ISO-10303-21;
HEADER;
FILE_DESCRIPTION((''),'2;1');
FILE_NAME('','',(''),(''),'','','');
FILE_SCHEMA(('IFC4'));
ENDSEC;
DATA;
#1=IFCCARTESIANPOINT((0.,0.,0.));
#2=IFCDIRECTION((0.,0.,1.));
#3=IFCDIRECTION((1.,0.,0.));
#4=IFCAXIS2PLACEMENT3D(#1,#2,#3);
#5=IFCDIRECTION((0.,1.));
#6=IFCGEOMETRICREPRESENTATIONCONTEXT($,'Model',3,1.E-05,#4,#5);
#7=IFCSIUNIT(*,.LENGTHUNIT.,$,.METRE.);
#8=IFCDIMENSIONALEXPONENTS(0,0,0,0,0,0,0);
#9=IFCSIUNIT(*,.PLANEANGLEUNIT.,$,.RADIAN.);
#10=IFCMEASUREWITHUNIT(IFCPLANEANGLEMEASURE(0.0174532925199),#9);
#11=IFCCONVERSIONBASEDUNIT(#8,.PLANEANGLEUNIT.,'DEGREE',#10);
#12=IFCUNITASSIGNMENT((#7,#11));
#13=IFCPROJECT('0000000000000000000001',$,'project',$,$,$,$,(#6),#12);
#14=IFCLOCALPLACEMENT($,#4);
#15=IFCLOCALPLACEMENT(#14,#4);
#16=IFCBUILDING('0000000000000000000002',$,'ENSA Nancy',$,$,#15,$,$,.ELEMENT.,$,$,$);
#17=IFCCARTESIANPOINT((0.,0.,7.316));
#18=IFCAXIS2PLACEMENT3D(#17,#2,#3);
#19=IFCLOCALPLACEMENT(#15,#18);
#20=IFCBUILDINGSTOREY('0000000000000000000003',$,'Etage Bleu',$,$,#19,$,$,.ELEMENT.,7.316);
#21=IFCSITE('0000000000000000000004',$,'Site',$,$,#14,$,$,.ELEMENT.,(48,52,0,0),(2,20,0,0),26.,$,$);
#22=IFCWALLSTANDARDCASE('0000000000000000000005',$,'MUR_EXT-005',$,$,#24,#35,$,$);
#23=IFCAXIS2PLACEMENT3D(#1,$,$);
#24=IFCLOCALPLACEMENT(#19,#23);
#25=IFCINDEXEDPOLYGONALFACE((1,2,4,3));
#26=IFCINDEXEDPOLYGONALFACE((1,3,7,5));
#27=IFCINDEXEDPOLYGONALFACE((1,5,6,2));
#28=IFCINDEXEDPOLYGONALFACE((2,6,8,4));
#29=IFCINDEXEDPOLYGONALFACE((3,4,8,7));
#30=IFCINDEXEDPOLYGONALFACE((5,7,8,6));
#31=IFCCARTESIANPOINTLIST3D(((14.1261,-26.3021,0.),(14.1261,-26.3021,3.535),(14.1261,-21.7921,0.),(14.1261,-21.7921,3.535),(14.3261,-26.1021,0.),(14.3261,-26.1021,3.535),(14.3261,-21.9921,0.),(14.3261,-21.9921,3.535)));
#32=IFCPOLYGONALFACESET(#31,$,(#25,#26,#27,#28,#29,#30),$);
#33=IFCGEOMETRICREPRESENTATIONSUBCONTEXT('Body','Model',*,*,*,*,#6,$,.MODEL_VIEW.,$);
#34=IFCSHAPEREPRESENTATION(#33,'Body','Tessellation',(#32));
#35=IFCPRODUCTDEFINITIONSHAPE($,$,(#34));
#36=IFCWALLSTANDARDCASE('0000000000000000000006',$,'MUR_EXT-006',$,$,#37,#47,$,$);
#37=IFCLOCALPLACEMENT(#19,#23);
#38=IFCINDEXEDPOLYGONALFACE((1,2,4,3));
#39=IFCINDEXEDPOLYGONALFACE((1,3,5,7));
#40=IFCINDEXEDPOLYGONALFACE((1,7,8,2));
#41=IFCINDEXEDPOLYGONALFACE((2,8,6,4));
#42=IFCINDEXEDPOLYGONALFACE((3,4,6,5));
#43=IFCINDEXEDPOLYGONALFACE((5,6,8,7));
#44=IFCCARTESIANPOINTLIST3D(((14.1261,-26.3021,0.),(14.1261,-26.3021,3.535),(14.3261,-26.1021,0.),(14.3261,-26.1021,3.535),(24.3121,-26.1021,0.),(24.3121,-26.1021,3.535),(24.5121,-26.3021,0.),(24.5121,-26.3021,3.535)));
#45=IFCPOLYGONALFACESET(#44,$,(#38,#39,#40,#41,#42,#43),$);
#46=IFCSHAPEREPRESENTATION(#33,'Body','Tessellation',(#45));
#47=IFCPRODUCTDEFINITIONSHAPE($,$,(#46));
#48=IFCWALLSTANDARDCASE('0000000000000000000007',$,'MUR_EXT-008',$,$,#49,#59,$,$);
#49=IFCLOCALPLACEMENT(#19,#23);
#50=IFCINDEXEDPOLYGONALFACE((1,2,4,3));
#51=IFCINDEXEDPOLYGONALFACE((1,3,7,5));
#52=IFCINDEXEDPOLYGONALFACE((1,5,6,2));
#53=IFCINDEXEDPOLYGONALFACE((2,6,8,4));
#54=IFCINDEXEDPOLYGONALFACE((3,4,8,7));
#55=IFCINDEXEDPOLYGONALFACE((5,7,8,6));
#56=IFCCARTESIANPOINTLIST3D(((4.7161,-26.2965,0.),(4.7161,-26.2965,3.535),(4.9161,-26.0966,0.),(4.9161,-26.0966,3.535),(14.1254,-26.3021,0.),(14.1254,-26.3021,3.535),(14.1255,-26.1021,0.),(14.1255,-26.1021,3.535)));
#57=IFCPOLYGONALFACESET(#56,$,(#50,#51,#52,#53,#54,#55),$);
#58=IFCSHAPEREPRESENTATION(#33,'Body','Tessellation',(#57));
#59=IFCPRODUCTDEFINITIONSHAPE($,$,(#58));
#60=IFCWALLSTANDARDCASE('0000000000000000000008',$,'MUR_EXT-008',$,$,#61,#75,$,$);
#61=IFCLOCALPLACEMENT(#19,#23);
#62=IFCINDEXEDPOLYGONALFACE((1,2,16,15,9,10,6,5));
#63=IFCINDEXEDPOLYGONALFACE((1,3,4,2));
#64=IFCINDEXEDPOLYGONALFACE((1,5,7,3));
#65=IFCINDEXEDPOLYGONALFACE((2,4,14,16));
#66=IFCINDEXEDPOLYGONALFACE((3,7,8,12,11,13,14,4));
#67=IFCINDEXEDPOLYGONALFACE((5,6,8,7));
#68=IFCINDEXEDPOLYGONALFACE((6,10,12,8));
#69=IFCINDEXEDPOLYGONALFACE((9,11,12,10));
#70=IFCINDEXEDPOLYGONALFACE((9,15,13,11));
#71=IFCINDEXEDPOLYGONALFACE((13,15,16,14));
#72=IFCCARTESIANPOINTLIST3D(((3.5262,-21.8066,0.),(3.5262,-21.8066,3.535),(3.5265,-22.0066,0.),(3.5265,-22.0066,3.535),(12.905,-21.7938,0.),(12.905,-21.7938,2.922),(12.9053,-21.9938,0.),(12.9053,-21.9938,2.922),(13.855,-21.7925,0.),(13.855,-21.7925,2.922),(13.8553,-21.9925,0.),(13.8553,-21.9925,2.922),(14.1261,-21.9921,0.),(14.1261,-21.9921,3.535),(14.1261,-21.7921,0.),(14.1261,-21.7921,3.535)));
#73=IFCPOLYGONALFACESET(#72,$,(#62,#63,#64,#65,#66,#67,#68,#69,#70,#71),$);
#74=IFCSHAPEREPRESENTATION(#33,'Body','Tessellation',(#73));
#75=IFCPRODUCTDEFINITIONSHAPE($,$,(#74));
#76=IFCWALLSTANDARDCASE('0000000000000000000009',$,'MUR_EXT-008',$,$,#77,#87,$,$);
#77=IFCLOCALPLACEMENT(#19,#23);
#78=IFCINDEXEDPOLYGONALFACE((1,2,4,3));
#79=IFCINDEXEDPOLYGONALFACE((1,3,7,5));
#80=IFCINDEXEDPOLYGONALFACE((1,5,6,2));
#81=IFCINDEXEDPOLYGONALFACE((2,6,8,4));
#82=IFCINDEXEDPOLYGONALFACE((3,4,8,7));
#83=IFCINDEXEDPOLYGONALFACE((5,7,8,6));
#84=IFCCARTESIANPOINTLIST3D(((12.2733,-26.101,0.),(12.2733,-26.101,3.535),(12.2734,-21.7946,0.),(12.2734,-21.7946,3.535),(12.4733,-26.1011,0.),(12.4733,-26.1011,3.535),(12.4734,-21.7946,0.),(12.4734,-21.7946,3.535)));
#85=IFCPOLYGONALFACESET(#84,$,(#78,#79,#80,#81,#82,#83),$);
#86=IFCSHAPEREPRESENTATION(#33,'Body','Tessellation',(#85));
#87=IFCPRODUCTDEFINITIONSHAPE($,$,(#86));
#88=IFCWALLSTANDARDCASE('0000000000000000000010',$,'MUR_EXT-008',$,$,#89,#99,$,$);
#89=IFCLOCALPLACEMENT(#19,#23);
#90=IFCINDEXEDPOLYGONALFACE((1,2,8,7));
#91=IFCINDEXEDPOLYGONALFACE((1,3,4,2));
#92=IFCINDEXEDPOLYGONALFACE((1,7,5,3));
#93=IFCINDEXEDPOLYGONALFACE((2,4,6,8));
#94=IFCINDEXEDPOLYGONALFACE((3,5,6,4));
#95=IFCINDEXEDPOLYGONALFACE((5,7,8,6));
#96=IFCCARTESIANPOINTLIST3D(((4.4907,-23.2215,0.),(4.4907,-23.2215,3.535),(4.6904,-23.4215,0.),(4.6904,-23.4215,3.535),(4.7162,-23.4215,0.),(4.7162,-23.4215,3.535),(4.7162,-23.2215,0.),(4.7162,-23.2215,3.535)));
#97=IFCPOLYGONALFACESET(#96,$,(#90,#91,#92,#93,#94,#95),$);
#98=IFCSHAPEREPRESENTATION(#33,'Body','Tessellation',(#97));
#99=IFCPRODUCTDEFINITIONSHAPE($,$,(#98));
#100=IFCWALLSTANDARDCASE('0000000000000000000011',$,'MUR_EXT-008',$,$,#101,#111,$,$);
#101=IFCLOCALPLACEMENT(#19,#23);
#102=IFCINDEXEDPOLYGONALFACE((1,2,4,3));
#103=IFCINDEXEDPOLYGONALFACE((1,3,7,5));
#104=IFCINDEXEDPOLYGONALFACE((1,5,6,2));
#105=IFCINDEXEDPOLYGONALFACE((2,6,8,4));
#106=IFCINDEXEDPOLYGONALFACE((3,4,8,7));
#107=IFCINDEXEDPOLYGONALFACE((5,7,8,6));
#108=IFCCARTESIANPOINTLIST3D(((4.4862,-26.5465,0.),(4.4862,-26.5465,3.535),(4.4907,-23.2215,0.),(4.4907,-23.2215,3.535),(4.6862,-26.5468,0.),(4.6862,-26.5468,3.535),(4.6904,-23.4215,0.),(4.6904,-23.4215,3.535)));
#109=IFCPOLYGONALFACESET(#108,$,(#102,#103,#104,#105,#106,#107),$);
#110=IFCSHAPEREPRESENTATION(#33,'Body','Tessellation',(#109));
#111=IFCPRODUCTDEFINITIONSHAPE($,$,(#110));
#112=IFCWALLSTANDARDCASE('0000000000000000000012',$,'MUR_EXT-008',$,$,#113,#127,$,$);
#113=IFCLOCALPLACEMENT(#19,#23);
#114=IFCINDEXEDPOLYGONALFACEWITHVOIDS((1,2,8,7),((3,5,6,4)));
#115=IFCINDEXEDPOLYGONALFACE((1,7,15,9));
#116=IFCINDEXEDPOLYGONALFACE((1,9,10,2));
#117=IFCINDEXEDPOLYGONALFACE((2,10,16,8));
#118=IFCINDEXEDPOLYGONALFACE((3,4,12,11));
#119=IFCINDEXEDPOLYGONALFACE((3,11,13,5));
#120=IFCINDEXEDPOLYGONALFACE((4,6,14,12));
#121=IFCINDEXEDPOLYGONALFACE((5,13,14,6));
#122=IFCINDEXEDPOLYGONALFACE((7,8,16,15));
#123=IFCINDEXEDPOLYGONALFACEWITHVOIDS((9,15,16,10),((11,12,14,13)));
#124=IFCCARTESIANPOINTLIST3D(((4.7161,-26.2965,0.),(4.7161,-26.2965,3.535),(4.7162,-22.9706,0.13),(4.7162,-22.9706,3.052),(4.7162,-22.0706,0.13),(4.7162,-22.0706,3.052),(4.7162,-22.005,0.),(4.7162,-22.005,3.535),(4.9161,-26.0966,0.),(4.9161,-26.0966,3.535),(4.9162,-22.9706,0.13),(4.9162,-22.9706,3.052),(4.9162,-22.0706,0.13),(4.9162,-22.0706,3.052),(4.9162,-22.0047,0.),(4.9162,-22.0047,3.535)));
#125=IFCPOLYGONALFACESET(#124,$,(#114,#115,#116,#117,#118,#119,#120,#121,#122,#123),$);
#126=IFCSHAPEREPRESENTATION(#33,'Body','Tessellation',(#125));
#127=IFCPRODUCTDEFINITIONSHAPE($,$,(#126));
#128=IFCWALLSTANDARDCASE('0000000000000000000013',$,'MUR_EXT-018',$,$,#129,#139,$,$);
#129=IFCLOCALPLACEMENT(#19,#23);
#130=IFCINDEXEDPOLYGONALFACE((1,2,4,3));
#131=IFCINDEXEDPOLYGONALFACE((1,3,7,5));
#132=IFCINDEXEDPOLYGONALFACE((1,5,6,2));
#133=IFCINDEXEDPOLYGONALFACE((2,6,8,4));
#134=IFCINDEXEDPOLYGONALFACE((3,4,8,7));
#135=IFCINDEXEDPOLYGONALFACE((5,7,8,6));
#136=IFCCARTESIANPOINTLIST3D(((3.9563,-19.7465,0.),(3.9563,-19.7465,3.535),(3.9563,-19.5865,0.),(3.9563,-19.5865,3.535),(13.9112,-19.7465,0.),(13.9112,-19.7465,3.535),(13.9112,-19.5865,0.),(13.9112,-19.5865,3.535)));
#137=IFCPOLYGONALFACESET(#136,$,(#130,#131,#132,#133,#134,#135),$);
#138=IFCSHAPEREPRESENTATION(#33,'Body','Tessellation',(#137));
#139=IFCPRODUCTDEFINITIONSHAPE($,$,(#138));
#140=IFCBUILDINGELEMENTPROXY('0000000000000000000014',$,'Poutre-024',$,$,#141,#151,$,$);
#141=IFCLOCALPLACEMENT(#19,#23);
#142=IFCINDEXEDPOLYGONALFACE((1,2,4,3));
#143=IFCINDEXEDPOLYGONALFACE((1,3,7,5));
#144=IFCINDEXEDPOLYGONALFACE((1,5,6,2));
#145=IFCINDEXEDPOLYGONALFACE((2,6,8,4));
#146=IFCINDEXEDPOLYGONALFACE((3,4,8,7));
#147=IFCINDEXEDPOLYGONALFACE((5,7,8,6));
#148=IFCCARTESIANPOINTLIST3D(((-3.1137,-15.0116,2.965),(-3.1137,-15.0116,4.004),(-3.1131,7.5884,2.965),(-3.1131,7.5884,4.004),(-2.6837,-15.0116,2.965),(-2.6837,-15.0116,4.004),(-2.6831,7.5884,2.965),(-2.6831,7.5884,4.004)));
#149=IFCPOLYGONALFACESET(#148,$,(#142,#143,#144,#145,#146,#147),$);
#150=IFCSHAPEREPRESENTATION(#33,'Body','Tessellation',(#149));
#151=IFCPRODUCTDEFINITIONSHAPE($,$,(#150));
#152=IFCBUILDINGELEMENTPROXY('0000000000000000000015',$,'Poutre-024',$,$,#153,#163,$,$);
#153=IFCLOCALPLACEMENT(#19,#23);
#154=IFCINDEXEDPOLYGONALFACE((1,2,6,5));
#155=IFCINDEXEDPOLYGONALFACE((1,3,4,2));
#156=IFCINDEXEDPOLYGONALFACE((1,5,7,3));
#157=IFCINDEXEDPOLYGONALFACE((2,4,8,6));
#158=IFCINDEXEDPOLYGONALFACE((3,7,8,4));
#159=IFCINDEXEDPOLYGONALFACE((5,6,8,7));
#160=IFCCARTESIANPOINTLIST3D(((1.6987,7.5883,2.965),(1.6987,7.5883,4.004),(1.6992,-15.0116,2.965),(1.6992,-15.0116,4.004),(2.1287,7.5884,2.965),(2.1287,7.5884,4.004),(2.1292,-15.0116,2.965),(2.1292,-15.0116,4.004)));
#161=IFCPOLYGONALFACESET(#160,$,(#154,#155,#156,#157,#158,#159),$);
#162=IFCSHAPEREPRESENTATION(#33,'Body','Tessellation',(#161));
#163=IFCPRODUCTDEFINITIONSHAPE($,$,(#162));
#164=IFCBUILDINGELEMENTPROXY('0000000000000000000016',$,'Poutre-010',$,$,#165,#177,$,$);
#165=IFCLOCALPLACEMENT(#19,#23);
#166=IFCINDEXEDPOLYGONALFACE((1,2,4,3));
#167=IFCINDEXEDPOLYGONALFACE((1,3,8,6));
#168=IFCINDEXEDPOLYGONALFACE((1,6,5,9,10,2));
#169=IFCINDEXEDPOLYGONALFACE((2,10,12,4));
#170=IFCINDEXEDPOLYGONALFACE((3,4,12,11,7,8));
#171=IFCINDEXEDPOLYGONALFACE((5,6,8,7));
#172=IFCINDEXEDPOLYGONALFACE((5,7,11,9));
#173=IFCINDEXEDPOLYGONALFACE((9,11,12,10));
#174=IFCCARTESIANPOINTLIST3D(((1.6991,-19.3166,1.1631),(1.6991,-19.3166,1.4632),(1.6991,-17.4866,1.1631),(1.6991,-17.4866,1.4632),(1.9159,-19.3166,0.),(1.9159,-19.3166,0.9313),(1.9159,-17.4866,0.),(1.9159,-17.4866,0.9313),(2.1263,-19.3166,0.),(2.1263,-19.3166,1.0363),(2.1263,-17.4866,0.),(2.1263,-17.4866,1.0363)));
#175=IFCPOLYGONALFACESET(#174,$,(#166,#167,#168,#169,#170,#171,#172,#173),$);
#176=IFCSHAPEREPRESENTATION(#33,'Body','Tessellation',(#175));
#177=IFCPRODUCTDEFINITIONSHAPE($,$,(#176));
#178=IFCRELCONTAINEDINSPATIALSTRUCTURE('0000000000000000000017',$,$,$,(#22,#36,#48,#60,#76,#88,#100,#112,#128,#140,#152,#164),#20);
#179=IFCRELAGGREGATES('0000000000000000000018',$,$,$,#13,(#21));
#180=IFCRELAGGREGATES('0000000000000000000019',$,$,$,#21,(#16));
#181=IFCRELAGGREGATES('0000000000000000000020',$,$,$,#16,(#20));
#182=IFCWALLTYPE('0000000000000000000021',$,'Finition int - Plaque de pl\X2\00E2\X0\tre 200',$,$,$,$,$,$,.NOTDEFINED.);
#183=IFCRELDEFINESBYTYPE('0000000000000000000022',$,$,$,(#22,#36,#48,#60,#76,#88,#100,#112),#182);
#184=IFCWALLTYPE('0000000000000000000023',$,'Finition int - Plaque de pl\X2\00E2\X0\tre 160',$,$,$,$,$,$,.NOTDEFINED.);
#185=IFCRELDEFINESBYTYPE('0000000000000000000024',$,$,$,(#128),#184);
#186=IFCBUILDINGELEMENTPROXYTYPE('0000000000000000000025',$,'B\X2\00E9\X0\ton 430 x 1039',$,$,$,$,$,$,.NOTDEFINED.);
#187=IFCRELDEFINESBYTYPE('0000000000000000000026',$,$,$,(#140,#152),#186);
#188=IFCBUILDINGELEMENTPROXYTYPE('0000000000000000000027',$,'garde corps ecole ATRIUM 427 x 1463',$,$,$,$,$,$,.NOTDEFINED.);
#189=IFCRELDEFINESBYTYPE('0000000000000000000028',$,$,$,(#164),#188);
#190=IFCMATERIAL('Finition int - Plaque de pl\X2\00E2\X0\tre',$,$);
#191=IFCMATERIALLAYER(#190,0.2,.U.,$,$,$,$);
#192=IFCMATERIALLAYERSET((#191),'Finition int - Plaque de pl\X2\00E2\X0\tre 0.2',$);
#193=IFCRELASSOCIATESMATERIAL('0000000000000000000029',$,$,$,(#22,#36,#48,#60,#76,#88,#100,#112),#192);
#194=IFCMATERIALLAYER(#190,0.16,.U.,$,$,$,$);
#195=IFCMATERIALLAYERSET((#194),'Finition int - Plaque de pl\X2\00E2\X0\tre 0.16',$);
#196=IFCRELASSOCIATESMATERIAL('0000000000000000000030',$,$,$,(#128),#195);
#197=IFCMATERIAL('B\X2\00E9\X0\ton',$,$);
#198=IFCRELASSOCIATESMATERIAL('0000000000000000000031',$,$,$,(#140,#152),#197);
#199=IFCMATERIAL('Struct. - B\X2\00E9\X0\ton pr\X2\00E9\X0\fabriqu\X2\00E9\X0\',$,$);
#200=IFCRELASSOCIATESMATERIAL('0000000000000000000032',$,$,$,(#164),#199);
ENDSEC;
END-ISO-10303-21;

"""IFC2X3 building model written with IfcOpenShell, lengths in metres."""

from ifc_helpers import new_model, entity, si_unit, converted_unit, direction, frame, frame_2d, origin_with_axes, origin_2d_with_axis, place, context, subcontext, project, spatial, polyline, rectangle, outline, extrude, material, layer, layer_set, layer_usage, type_object, element, save


model = new_model("IFC2X3")

# Units and contexts
model_context = context("Model", 3, precision=1e-05, world=origin_with_axes(), true_north=direction((0.0, 1.0)))
body_context = subcontext(model_context, "Body", "Model", "MODEL_VIEW")
ifc_project = project(units=[si_unit("LENGTHUNIT", "METRE"), converted_unit("PLANEANGLEUNIT", "DEGREE", entity("IfcPlaneAngleMeasure", 0.0174532925199), si_unit("PLANEANGLEUNIT", "RADIAN"), dimensions=[0, 0, 0, 0, 0, 0, 0])], contexts=[model_context])

# Site, building, storey
site_placement = place(None, origin_with_axes())
site = spatial("IfcSite", under=ifc_project, at=site_placement, Name="Site", CompositionType="ELEMENT", RefLatitude=(48, 52, 0, 0), RefLongitude=(2, 20, 0, 0), RefElevation=26.0)
building_placement = place(site_placement, origin_with_axes())
building = spatial("IfcBuilding", under=site, at=building_placement, Name="ENSA Nancy", CompositionType="ELEMENT")
storey_placement = place(building_placement, frame((0.0, 0.0, 7.316), z_axis=(0.0, 0.0, 1.0), x_axis=(1.0, 0.0, 0.0)))
storey = spatial("IfcBuildingStorey", under=building, at=storey_placement, Name="Etage Bleu", CompositionType="ELEMENT", Elevation=7.316)

# Walls
ifc_material_1 = material(Name="Finition int - Plaque de plâtre")
ifc_layer_1 = layer(ifc_material_1, 0.2, ventilated="UNKNOWN")
ifc_layer_set_1 = layer_set([ifc_layer_1], Name="Finition int - Plaque de plâtre 0.2")
ifc_layer_usage_1 = layer_usage(ifc_layer_set_1, "AXIS2", "POSITIVE", 0.0)
wall_type_1 = type_object("IfcWallType", Name="Finition int - Plaque de plâtre 200", PredefinedType="NOTDEFINED")
wall_1_placement = place(storey_placement, frame((14.1261, -21.7921, 0.0), z_axis=(0.0, 0.0, 1.0), x_axis=(0.0, -1.0, 0.0)))
element("IfcWallStandardCase", 1, at=wall_1_placement, inside=storey, type_object=wall_type_1, material=ifc_layer_usage_1, Name="MUR_EXT-005", context=body_context, shape_type="SweptSolid", body=[
    extrude(outline(polyline([(0.0, 0.0), (4.51, 0.0), (4.31, 0.2), (0.2, 0.2), (0.0, 0.0)])), origin_with_axes(), (0.0, 0.0, 1.0), 3.535),
])
ifc_layer_usage_2 = layer_usage(ifc_layer_set_1, "AXIS2", "POSITIVE", 0.0)
wall_2_placement = place(storey_placement, frame((14.1261, -26.3021, 0.0), z_axis=(0.0, 0.0, 1.0), x_axis=(1.0, 0.000003, 0.0)))
element("IfcWallStandardCase", 2, at=wall_2_placement, inside=storey, type_object=wall_type_1, material=ifc_layer_usage_2, Name="MUR_EXT-006", context=body_context, shape_type="SweptSolid", body=[
    extrude(outline(polyline([(0.0, 0.0), (10.386, 0.0), (10.186, 0.2), (0.2, 0.2), (0.0, 0.0)])), origin_with_axes(), (0.0, 0.0, 1.0), 3.535),
])
ifc_layer_usage_3 = layer_usage(ifc_layer_set_1, "AXIS2", "POSITIVE", 0.0)
wall_3_placement = place(storey_placement, frame((4.7161, -26.2965, 0.0), z_axis=(0.0, 0.0, 1.0), x_axis=(1.0, -0.000596, 0.0)))
element("IfcWallStandardCase", 3, at=wall_3_placement, inside=storey, type_object=wall_type_1, material=ifc_layer_usage_3, Name="MUR_EXT-008", context=body_context, shape_type="SweptSolid", body=[
    extrude(outline(polyline([(0.0, 0.0), (9.4092, 0.0), (9.4092, 0.2), (0.1999, 0.2), (0.0, 0.0)])), origin_with_axes(), (0.0, 0.0, 1.0), 3.535),
])

# Wall, opening
ifc_layer_usage_4 = layer_usage(ifc_layer_set_1, "AXIS2", "NEGATIVE", 0.0)
wall_4_placement = place(storey_placement, frame((3.5262, -21.8066, 0.0), z_axis=(0.0, 0.0, 1.0), x_axis=(0.999999, 0.001365, 0.0)))
wall_4 = element("IfcWallStandardCase", 4, at=wall_4_placement, inside=storey, type_object=wall_type_1, material=ifc_layer_usage_4, Name="MUR_EXT-008", context=body_context, shape_type="SweptSolid", body=[
    extrude(outline(polyline([(0.0, -0.2), (10.5996, -0.2), (10.5999, 0.0), (0.0, 0.0), (0.0, -0.2)])), origin_with_axes(), (0.0, 0.0, 1.0), 3.535),
])
opening_1_placement = place(wall_4_placement, frame((9.8538, 0.0, 0.0), z_axis=(0.0, 0.0, 1.0), x_axis=(1.0, 0.0, 0.0)))
element("IfcOpeningElement", 5, at=opening_1_placement, cuts=wall_4, context=body_context, shape_type="SweptSolid", body=[
    extrude(rectangle(XDim=0.95, YDim=2.922, at=origin_2d_with_axis()), frame((0.0, -0.2, 1.461), z_axis=(0.0, 1.0, 0.0), x_axis=(1.0, 0.0, 0.0)), (0.0, 0.0, 1.0), 0.6),
])

# Walls
ifc_layer_usage_5 = layer_usage(ifc_layer_set_1, "AXIS2", "POSITIVE", 0.0)
wall_5_placement = place(storey_placement, frame((12.2734, -21.7946, 0.0), z_axis=(0.0, 0.0, 1.0), x_axis=(-0.000007, -1.0, 0.0)))
element("IfcWallStandardCase", 6, at=wall_5_placement, inside=storey, type_object=wall_type_1, material=ifc_layer_usage_5, Name="MUR_EXT-008", context=body_context, shape_type="SweptSolid", body=[
    extrude(outline(polyline([(0.0, 0.0), (4.3065, 0.0), (4.3066, 0.2), (0.0, 0.2), (0.0, 0.0)])), origin_with_axes(), (0.0, 0.0, 1.0), 3.535),
])
ifc_layer_usage_6 = layer_usage(ifc_layer_set_1, "AXIS2", "POSITIVE", 0.0)
wall_6_placement = place(storey_placement, frame((4.7162, -23.2215, 0.0), z_axis=(0.0, 0.0, 1.0), x_axis=(-1.0, 0.0, 0.0)))
element("IfcWallStandardCase", 7, at=wall_6_placement, inside=storey, type_object=wall_type_1, material=ifc_layer_usage_6, Name="MUR_EXT-008", context=body_context, shape_type="SweptSolid", body=[
    extrude(outline(polyline([(0.0, 0.0), (0.2255, 0.0), (0.0258, 0.2), (0.0, 0.2), (0.0, 0.0)])), origin_with_axes(), (0.0, 0.0, 1.0), 3.535),
])
ifc_layer_usage_7 = layer_usage(ifc_layer_set_1, "AXIS2", "POSITIVE", 0.0)
wall_7_placement = place(storey_placement, frame((4.4907, -23.2215, 0.0), z_axis=(0.0, 0.0, 1.0), x_axis=(-0.001341, -0.999999, 0.0)))
element("IfcWallStandardCase", 8, at=wall_7_placement, inside=storey, type_object=wall_type_1, material=ifc_layer_usage_7, Name="MUR_EXT-008", context=body_context, shape_type="SweptSolid", body=[
    extrude(outline(polyline([(0.0, 0.0), (3.325, 0.0), (3.325, 0.2), (0.1997, 0.2), (0.0, 0.0)])), origin_with_axes(), (0.0, 0.0, 1.0), 3.535),
])

# Wall, opening
ifc_layer_usage_8 = layer_usage(ifc_layer_set_1, "AXIS2", "POSITIVE", 0.0)
wall_8_placement = place(storey_placement, frame((4.7162, -21.805, 0.0), z_axis=(0.0, 0.0, 1.0), x_axis=(-0.000007, -1.0, 0.0)))
wall_8 = element("IfcWallStandardCase", 9, at=wall_8_placement, inside=storey, type_object=wall_type_1, material=ifc_layer_usage_8, Name="MUR_EXT-008", context=body_context, shape_type="SweptSolid", body=[
    extrude(outline(polyline([(0.2, 0.0), (4.4915, 0.0), (4.2917, 0.2), (0.1997, 0.2), (0.2, 0.0)])), origin_with_axes(), (0.0, 0.0, 1.0), 3.535),
])
opening_2_placement = place(wall_8_placement, frame((0.7156, 0.0, 0.13), z_axis=(0.0, 0.0, 1.0), x_axis=(1.0, 0.0, 0.0)))
element("IfcOpeningElement", 10, at=opening_2_placement, cuts=wall_8, context=body_context, shape_type="SweptSolid", body=[
    extrude(rectangle(XDim=0.9, YDim=2.922, at=origin_2d_with_axis()), frame((0.0, 0.2, 1.461), z_axis=(0.0, 1.0, 0.0), x_axis=(-1.0, 0.0, 0.0)), (0.0, 0.0, -1.0), 0.6),
])

# Wall
ifc_layer_2 = layer(ifc_material_1, 0.16, ventilated="UNKNOWN")
ifc_layer_set_2 = layer_set([ifc_layer_2], Name="Finition int - Plaque de plâtre 0.16")
ifc_layer_usage_9 = layer_usage(ifc_layer_set_2, "AXIS2", "POSITIVE", -0.16)
wall_type_2 = type_object("IfcWallType", Name="Finition int - Plaque de plâtre 160", PredefinedType="NOTDEFINED")
wall_9_placement = place(storey_placement, frame((3.9563, -19.5865, 0.0), z_axis=(0.0, 0.0, 1.0), x_axis=(1.0, 0.0, 0.0)))
element("IfcWallStandardCase", 11, at=wall_9_placement, inside=storey, type_object=wall_type_2, material=ifc_layer_usage_9, Name="MUR_EXT-018", context=body_context, shape_type="SweptSolid", body=[
    extrude(outline(polyline([(0.0, -0.16), (9.955, -0.16), (9.955, 0.0), (0.0, 0.0), (0.0, -0.16)])), origin_with_axes(), (0.0, 0.0, 1.0), 3.535),
])

# Building element proxies
ifc_material_2 = material(Name="Béton")
building_element_proxy_type_1 = type_object("IfcBuildingElementProxyType", Name="Béton 430 x 1039", PredefinedType="NOTDEFINED")
proxy_1_placement = place(storey_placement, frame((-2.8987, -15.0116, 4.004), z_axis=(0.0, 0.0, 1.0), x_axis=(1.0, -0.000026, 0.0)))
element("IfcBuildingElementProxy", 12, at=proxy_1_placement, inside=storey, type_object=building_element_proxy_type_1, material=ifc_material_2, Name="Poutre-024", context=body_context, shape_type="SweptSolid", body=[
    extrude(rectangle(XDim=1.039, YDim=0.43, at=frame_2d((-0.5195, 0.0), x_axis=(1.0, 0.0))), frame((0.0, 0.0, 0.0), z_axis=(0.0, 1.0, 0.0), x_axis=(0.0, 0.0, 1.0)), (0.0, 0.0, 1.0), 22.6),
])
proxy_2_placement = place(storey_placement, frame((1.9142, -15.0116, 4.004), z_axis=(0.0, 0.0, 1.0), x_axis=(1.0, 0.000024, 0.0)))
element("IfcBuildingElementProxy", 13, at=proxy_2_placement, inside=storey, type_object=building_element_proxy_type_1, material=ifc_material_2, Name="Poutre-024", context=body_context, shape_type="SweptSolid", body=[
    extrude(rectangle(XDim=1.039, YDim=0.43, at=frame_2d((-0.5195, 0.0), x_axis=(1.0, 0.0))), frame((0.0, 0.0, 0.0), z_axis=(0.0, 1.0, 0.0), x_axis=(0.0, 0.0, 1.0)), (0.0, 0.0, 1.0), 22.6),
])
ifc_material_3 = material(Name="Struct. - Béton préfabriqué")
building_element_proxy_type_2 = type_object("IfcBuildingElementProxyType", Name="garde corps ecole ATRIUM 427 x 1463", PredefinedType="NOTDEFINED")
proxy_3_placement = place(storey_placement, frame((2.1263, -19.3166, 0.0), z_axis=(0.0, 0.0, 1.0), x_axis=(1.0, 0.0, 0.0)))
element("IfcBuildingElementProxy", 14, at=proxy_3_placement, inside=storey, type_object=building_element_proxy_type_2, material=ifc_material_3, Name="Poutre-010", context=body_context, shape_type="SweptSolid", body=[
    extrude(outline(polyline([(0.0, 1.0363), (0.0, 0.0), (0.2105, 0.0), (0.2105, 0.9313), (0.4272, 1.1631), (0.4272, 1.4632), (0.0, 1.0363)])), frame((0.0, 1.83, 0.0), z_axis=(0.0, 1.0, 0.0), x_axis=(-1.0, 0.0, 0.0)), (0.0, 0.0, -1.0), 1.83),
])

save(model, "model.ifc")
